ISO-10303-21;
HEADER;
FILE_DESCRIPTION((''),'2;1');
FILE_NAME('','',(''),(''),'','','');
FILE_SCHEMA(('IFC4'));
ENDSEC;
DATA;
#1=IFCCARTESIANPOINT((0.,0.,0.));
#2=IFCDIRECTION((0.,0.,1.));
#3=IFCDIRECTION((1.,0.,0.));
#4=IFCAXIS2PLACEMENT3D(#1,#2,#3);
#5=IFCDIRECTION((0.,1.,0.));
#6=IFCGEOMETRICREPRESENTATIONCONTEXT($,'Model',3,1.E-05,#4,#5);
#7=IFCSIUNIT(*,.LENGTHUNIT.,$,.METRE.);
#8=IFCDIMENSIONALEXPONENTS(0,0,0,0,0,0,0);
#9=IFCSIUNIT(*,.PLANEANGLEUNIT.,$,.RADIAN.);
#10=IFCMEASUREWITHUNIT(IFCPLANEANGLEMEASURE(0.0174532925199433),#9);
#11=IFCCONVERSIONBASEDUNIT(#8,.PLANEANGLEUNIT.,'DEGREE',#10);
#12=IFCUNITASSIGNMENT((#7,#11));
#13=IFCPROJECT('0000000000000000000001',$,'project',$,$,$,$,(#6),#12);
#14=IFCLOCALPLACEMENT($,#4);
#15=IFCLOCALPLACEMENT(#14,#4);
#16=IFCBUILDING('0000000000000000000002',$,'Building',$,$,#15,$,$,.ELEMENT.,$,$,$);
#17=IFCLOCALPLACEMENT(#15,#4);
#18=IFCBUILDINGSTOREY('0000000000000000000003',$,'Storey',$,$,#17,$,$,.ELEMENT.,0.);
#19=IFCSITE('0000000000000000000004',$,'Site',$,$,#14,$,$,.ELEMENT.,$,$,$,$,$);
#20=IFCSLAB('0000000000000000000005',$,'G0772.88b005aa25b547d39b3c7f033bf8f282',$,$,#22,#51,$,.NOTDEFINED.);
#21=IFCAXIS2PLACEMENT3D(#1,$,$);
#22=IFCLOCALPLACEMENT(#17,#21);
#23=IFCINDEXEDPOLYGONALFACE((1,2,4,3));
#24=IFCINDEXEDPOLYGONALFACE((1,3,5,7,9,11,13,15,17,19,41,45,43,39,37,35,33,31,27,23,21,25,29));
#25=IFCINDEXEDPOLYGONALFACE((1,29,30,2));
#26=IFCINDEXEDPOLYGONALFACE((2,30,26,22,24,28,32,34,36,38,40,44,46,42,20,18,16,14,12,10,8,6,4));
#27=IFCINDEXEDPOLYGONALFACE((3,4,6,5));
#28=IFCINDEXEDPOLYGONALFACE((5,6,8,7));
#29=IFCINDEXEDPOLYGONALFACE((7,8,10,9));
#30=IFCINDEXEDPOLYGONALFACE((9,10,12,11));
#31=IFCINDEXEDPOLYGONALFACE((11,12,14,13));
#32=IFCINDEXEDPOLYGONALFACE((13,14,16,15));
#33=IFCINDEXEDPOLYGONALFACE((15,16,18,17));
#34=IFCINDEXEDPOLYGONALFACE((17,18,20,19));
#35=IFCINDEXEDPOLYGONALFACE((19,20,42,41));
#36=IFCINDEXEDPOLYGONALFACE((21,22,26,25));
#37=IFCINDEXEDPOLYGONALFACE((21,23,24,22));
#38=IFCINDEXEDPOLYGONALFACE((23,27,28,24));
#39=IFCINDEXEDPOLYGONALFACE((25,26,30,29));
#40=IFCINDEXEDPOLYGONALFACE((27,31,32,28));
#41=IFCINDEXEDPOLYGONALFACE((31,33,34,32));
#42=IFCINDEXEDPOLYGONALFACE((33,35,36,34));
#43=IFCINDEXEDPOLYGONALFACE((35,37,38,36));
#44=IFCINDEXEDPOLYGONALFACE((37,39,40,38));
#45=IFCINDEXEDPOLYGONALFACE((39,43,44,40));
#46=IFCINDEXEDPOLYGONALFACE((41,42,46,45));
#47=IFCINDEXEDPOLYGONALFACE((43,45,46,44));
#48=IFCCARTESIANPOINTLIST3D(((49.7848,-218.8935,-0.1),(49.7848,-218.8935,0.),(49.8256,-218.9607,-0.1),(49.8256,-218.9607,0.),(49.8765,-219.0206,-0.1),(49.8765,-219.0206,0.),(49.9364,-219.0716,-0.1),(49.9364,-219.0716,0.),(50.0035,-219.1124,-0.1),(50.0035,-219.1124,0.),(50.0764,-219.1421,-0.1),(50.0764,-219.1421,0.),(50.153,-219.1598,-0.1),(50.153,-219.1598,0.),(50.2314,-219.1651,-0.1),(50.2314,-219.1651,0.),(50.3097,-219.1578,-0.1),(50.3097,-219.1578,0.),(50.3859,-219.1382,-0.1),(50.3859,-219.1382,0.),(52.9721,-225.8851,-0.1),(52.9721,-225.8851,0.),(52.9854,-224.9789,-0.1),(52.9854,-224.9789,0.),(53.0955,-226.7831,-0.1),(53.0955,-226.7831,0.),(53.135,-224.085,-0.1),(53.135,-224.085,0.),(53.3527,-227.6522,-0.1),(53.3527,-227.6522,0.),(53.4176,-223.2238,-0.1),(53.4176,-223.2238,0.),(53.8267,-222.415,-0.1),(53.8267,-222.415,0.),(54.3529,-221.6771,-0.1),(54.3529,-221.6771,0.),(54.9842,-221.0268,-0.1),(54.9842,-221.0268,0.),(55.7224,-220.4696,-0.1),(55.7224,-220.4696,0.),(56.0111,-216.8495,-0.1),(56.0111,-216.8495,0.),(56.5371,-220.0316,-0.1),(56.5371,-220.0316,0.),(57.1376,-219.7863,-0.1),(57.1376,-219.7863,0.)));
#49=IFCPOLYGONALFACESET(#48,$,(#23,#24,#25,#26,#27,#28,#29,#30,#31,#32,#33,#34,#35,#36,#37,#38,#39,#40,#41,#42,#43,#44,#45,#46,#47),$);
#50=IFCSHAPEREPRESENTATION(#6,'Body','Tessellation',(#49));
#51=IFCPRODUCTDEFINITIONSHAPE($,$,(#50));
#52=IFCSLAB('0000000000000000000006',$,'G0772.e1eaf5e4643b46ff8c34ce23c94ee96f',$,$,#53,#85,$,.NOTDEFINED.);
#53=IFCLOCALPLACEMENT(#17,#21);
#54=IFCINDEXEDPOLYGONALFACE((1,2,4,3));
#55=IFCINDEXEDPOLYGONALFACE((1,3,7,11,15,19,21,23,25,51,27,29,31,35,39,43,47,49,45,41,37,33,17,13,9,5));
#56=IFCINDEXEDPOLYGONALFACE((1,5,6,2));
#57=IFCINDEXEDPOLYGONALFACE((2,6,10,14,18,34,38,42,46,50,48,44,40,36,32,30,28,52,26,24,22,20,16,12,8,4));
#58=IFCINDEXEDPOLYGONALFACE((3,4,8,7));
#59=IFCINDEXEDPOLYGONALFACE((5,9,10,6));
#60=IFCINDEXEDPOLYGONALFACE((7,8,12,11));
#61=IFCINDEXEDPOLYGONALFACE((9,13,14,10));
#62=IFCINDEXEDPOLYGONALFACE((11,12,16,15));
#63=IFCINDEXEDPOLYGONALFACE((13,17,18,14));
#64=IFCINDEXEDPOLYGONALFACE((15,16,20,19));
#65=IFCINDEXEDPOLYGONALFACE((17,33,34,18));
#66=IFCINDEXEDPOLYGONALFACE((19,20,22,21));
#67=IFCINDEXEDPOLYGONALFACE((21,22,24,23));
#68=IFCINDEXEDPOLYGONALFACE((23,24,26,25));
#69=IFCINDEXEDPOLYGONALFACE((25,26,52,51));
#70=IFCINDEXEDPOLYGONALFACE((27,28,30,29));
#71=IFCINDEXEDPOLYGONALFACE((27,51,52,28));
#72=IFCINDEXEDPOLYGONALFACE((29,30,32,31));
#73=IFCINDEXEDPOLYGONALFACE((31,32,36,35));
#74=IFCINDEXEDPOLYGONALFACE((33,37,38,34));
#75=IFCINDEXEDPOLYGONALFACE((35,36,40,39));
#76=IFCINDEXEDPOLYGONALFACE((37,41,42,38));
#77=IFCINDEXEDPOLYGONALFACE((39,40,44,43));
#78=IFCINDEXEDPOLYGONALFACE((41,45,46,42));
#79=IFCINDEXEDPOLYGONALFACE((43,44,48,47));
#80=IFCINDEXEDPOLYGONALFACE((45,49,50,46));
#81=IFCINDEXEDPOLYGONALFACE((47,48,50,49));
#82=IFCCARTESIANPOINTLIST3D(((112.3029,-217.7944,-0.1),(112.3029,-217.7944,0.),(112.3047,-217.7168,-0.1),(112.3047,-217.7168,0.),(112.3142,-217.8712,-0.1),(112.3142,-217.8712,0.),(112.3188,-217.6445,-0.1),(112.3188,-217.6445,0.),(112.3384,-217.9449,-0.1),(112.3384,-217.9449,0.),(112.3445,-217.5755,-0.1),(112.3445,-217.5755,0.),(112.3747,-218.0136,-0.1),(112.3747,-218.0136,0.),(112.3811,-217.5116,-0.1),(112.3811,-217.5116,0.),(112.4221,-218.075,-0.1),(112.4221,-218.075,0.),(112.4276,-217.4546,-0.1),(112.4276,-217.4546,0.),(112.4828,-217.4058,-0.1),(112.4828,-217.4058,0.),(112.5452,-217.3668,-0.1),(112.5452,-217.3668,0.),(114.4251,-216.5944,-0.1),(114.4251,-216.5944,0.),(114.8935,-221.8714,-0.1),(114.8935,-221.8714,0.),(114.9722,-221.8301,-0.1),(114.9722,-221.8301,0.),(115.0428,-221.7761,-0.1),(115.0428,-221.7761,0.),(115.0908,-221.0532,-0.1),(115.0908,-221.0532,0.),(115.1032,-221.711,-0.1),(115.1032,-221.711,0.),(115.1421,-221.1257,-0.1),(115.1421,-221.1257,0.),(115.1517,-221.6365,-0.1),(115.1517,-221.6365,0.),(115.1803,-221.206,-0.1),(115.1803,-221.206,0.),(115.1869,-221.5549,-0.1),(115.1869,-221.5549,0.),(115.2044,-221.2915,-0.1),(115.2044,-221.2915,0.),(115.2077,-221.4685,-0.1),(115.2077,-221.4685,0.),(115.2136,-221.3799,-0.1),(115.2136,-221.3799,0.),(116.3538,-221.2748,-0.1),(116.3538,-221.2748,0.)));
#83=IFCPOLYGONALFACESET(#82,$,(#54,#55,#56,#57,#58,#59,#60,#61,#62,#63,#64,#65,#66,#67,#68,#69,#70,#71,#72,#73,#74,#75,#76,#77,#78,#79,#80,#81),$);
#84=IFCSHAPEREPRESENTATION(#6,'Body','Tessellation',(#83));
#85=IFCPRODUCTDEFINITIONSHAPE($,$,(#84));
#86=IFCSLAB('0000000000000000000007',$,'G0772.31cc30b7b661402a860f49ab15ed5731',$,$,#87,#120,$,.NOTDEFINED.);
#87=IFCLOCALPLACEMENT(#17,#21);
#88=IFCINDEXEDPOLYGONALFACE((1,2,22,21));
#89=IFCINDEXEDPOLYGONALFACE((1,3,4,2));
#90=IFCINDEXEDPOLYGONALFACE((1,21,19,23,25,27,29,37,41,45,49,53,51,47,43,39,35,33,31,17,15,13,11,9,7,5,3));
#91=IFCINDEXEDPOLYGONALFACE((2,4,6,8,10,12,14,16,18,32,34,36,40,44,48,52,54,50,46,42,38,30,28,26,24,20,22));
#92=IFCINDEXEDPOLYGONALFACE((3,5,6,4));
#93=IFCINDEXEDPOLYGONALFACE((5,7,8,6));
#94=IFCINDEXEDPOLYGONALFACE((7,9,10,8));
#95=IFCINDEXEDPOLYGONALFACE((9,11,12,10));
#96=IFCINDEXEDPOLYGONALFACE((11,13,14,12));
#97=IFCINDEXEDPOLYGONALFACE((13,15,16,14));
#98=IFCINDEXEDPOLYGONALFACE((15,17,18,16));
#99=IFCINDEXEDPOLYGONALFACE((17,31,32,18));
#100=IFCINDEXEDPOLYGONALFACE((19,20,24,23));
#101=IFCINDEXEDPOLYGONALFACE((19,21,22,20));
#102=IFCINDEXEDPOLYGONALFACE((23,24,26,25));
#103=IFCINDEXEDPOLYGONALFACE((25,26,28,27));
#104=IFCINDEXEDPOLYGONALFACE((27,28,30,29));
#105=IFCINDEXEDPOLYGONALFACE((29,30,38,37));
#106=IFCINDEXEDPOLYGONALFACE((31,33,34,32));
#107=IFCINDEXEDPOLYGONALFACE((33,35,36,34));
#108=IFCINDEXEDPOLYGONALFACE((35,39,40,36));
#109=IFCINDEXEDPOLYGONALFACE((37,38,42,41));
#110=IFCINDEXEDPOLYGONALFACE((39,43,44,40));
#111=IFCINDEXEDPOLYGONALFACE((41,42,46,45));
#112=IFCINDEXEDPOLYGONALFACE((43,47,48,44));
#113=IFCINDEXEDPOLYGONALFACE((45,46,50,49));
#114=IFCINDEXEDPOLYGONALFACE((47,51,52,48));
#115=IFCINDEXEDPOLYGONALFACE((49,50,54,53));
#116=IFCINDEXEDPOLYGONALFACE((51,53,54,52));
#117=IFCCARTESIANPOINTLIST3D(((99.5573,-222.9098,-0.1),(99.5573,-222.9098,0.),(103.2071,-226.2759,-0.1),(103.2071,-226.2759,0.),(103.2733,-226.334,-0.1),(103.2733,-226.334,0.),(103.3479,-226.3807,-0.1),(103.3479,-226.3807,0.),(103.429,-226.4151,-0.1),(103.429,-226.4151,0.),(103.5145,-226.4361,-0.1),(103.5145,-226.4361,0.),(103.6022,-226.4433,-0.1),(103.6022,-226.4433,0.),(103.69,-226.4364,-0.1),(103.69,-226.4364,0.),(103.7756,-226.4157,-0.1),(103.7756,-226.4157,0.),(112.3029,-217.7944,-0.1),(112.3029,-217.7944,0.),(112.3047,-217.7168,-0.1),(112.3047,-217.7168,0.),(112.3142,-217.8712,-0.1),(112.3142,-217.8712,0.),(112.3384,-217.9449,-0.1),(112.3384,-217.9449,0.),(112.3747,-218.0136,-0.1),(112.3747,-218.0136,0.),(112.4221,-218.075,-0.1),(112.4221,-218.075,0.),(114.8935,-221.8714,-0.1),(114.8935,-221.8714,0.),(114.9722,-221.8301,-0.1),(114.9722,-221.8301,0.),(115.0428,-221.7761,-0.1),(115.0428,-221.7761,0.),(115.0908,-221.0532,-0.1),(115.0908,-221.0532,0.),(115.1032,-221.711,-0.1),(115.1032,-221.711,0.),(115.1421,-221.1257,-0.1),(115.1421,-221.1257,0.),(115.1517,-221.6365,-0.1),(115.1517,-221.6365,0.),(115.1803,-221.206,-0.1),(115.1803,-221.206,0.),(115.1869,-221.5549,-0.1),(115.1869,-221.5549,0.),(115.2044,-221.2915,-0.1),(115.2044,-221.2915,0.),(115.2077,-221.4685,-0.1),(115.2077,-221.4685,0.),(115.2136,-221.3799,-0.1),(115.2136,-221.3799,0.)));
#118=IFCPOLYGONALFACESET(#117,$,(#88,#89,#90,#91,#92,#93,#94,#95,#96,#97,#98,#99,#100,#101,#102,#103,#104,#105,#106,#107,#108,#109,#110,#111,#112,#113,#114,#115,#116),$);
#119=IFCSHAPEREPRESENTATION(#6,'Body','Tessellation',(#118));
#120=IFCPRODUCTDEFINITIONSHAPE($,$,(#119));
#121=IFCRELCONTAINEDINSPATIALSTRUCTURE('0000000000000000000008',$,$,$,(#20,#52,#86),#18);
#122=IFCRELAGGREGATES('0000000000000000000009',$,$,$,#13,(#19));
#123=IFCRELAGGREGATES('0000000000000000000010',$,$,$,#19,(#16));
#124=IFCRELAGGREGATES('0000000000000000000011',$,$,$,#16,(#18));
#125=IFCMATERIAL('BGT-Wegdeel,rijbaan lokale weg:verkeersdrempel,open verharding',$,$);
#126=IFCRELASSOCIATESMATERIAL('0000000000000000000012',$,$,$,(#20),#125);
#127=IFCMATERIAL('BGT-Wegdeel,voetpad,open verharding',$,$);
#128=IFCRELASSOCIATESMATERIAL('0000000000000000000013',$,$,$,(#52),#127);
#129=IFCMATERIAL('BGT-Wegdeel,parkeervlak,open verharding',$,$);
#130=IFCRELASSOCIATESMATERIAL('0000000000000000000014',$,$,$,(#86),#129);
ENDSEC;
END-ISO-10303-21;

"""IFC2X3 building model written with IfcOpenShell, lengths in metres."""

from ifc_helpers import new_model, entity, si_unit, converted_unit, direction, frame, origin_with_axes, place, context, project, spatial, polyline, outline, extrude, material, element, save


model = new_model("IFC2X3")

# Units and contexts
model_context = context("Model", 3, precision=1e-05, world=origin_with_axes(), true_north=direction((0.0, 1.0, 0.0)))
ifc_project = project(units=[si_unit("LENGTHUNIT", "METRE"), converted_unit("PLANEANGLEUNIT", "DEGREE", entity("IfcPlaneAngleMeasure", 0.0174532925199433), si_unit("PLANEANGLEUNIT", "RADIAN"), dimensions=[0, 0, 0, 0, 0, 0, 0])], contexts=[model_context])

# Site, building, storey
site_placement = place(None, origin_with_axes())
site = spatial("IfcSite", under=ifc_project, at=site_placement, Name="Site", CompositionType="ELEMENT")
building_placement = place(site_placement, origin_with_axes())
building = spatial("IfcBuilding", under=site, at=building_placement, Name="Building", CompositionType="ELEMENT")
storey_placement = place(building_placement, origin_with_axes())
storey = spatial("IfcBuildingStorey", under=building, at=storey_placement, Name="Storey", CompositionType="ELEMENT", Elevation=0.0)

# Slabs
ifc_material_1 = material(Name="BGT-Wegdeel,voetpad,open verharding")
ifc_material_2 = material(Name="BGT-Wegdeel,parkeervlak,open verharding")
ifc_material_3 = material(Name="BGT-Wegdeel,rijbaan lokale weg:verkeersdrempel,open verharding")
slab_1_placement = place(storey_placement, frame((0.0, 0.0, -0.1), z_axis=(0.0, 0.0, 1.0), x_axis=(1.0, 0.0, 0.0)))
element("IfcSlab", 1, at=slab_1_placement, inside=storey, material=ifc_material_3, Name="G0772.88b005aa25b547d39b3c7f033bf8f282", PredefinedType="NOTDEFINED", context=model_context, shape_type="SweptSolid", body=[
    extrude(outline(polyline([(57.1376, -219.7863), (56.5371, -220.0316), (55.7224, -220.4696), (54.9842, -221.0268), (54.3529, -221.6771), (53.8267, -222.415), (53.4176, -223.2238), (53.135, -224.085), (52.9854, -224.9789), (52.9721, -225.8851), (53.0955, -226.7831), (53.3527, -227.6522), (49.7848, -218.8935), (49.8256, -218.9607), (49.8765, -219.0206), (49.9364, -219.0716), (50.0035, -219.1124), (50.0764, -219.1421), (50.153, -219.1598), (50.2314, -219.1651), (50.3097, -219.1578), (50.3859, -219.1382), (56.0111, -216.8495), (57.1376, -219.7863)])), origin_with_axes(), (0.0, 0.0, 1.0), 0.1),
])
slab_2_placement = place(storey_placement, frame((0.0, 0.0, -0.1), z_axis=(0.0, 0.0, 1.0), x_axis=(1.0, 0.0, 0.0)))
element("IfcSlab", 2, at=slab_2_placement, inside=storey, material=ifc_material_1, Name="G0772.e1eaf5e4643b46ff8c34ce23c94ee96f", PredefinedType="NOTDEFINED", context=model_context, shape_type="SweptSolid", body=[
    extrude(outline(polyline([(116.3538, -221.2748), (114.8935, -221.8714), (114.9722, -221.8301), (115.0428, -221.7761), (115.1032, -221.711), (115.1517, -221.6365), (115.1869, -221.5549), (115.2077, -221.4685), (115.2136, -221.3799), (115.2044, -221.2915), (115.1803, -221.206), (115.1421, -221.1257), (115.0908, -221.0532), (112.4221, -218.075), (112.3747, -218.0136), (112.3384, -217.9449), (112.3142, -217.8712), (112.3029, -217.7944), (112.3047, -217.7168), (112.3188, -217.6445), (112.3445, -217.5755), (112.3811, -217.5116), (112.4276, -217.4546), (112.4828, -217.4058), (112.5452, -217.3668), (114.4251, -216.5944), (116.3538, -221.2748)])), origin_with_axes(), (0.0, 0.0, 1.0), 0.1),
])
slab_3_placement = place(storey_placement, frame((0.0, 0.0, -0.1), z_axis=(0.0, 0.0, 1.0), x_axis=(1.0, 0.0, 0.0)))
element("IfcSlab", 3, at=slab_3_placement, inside=storey, material=ifc_material_2, Name="G0772.31cc30b7b661402a860f49ab15ed5731", PredefinedType="NOTDEFINED", context=model_context, shape_type="SweptSolid", body=[
    extrude(outline(polyline([(112.3047, -217.7168), (112.3029, -217.7944), (112.3142, -217.8712), (112.3384, -217.9449), (112.3747, -218.0136), (112.4221, -218.075), (115.0908, -221.0532), (115.1421, -221.1257), (115.1803, -221.206), (115.2044, -221.2915), (115.2136, -221.3799), (115.2077, -221.4685), (115.1869, -221.5549), (115.1517, -221.6365), (115.1032, -221.711), (115.0428, -221.7761), (114.9722, -221.8301), (114.8935, -221.8714), (103.7756, -226.4157), (103.69, -226.4364), (103.6022, -226.4433), (103.5145, -226.4361), (103.429, -226.4151), (103.3479, -226.3807), (103.2733, -226.334), (103.2071, -226.2759), (99.5573, -222.9098), (112.3047, -217.7168)])), origin_with_axes(), (0.0, 0.0, 1.0), 0.1),
])

save(model, "model.ifc")
